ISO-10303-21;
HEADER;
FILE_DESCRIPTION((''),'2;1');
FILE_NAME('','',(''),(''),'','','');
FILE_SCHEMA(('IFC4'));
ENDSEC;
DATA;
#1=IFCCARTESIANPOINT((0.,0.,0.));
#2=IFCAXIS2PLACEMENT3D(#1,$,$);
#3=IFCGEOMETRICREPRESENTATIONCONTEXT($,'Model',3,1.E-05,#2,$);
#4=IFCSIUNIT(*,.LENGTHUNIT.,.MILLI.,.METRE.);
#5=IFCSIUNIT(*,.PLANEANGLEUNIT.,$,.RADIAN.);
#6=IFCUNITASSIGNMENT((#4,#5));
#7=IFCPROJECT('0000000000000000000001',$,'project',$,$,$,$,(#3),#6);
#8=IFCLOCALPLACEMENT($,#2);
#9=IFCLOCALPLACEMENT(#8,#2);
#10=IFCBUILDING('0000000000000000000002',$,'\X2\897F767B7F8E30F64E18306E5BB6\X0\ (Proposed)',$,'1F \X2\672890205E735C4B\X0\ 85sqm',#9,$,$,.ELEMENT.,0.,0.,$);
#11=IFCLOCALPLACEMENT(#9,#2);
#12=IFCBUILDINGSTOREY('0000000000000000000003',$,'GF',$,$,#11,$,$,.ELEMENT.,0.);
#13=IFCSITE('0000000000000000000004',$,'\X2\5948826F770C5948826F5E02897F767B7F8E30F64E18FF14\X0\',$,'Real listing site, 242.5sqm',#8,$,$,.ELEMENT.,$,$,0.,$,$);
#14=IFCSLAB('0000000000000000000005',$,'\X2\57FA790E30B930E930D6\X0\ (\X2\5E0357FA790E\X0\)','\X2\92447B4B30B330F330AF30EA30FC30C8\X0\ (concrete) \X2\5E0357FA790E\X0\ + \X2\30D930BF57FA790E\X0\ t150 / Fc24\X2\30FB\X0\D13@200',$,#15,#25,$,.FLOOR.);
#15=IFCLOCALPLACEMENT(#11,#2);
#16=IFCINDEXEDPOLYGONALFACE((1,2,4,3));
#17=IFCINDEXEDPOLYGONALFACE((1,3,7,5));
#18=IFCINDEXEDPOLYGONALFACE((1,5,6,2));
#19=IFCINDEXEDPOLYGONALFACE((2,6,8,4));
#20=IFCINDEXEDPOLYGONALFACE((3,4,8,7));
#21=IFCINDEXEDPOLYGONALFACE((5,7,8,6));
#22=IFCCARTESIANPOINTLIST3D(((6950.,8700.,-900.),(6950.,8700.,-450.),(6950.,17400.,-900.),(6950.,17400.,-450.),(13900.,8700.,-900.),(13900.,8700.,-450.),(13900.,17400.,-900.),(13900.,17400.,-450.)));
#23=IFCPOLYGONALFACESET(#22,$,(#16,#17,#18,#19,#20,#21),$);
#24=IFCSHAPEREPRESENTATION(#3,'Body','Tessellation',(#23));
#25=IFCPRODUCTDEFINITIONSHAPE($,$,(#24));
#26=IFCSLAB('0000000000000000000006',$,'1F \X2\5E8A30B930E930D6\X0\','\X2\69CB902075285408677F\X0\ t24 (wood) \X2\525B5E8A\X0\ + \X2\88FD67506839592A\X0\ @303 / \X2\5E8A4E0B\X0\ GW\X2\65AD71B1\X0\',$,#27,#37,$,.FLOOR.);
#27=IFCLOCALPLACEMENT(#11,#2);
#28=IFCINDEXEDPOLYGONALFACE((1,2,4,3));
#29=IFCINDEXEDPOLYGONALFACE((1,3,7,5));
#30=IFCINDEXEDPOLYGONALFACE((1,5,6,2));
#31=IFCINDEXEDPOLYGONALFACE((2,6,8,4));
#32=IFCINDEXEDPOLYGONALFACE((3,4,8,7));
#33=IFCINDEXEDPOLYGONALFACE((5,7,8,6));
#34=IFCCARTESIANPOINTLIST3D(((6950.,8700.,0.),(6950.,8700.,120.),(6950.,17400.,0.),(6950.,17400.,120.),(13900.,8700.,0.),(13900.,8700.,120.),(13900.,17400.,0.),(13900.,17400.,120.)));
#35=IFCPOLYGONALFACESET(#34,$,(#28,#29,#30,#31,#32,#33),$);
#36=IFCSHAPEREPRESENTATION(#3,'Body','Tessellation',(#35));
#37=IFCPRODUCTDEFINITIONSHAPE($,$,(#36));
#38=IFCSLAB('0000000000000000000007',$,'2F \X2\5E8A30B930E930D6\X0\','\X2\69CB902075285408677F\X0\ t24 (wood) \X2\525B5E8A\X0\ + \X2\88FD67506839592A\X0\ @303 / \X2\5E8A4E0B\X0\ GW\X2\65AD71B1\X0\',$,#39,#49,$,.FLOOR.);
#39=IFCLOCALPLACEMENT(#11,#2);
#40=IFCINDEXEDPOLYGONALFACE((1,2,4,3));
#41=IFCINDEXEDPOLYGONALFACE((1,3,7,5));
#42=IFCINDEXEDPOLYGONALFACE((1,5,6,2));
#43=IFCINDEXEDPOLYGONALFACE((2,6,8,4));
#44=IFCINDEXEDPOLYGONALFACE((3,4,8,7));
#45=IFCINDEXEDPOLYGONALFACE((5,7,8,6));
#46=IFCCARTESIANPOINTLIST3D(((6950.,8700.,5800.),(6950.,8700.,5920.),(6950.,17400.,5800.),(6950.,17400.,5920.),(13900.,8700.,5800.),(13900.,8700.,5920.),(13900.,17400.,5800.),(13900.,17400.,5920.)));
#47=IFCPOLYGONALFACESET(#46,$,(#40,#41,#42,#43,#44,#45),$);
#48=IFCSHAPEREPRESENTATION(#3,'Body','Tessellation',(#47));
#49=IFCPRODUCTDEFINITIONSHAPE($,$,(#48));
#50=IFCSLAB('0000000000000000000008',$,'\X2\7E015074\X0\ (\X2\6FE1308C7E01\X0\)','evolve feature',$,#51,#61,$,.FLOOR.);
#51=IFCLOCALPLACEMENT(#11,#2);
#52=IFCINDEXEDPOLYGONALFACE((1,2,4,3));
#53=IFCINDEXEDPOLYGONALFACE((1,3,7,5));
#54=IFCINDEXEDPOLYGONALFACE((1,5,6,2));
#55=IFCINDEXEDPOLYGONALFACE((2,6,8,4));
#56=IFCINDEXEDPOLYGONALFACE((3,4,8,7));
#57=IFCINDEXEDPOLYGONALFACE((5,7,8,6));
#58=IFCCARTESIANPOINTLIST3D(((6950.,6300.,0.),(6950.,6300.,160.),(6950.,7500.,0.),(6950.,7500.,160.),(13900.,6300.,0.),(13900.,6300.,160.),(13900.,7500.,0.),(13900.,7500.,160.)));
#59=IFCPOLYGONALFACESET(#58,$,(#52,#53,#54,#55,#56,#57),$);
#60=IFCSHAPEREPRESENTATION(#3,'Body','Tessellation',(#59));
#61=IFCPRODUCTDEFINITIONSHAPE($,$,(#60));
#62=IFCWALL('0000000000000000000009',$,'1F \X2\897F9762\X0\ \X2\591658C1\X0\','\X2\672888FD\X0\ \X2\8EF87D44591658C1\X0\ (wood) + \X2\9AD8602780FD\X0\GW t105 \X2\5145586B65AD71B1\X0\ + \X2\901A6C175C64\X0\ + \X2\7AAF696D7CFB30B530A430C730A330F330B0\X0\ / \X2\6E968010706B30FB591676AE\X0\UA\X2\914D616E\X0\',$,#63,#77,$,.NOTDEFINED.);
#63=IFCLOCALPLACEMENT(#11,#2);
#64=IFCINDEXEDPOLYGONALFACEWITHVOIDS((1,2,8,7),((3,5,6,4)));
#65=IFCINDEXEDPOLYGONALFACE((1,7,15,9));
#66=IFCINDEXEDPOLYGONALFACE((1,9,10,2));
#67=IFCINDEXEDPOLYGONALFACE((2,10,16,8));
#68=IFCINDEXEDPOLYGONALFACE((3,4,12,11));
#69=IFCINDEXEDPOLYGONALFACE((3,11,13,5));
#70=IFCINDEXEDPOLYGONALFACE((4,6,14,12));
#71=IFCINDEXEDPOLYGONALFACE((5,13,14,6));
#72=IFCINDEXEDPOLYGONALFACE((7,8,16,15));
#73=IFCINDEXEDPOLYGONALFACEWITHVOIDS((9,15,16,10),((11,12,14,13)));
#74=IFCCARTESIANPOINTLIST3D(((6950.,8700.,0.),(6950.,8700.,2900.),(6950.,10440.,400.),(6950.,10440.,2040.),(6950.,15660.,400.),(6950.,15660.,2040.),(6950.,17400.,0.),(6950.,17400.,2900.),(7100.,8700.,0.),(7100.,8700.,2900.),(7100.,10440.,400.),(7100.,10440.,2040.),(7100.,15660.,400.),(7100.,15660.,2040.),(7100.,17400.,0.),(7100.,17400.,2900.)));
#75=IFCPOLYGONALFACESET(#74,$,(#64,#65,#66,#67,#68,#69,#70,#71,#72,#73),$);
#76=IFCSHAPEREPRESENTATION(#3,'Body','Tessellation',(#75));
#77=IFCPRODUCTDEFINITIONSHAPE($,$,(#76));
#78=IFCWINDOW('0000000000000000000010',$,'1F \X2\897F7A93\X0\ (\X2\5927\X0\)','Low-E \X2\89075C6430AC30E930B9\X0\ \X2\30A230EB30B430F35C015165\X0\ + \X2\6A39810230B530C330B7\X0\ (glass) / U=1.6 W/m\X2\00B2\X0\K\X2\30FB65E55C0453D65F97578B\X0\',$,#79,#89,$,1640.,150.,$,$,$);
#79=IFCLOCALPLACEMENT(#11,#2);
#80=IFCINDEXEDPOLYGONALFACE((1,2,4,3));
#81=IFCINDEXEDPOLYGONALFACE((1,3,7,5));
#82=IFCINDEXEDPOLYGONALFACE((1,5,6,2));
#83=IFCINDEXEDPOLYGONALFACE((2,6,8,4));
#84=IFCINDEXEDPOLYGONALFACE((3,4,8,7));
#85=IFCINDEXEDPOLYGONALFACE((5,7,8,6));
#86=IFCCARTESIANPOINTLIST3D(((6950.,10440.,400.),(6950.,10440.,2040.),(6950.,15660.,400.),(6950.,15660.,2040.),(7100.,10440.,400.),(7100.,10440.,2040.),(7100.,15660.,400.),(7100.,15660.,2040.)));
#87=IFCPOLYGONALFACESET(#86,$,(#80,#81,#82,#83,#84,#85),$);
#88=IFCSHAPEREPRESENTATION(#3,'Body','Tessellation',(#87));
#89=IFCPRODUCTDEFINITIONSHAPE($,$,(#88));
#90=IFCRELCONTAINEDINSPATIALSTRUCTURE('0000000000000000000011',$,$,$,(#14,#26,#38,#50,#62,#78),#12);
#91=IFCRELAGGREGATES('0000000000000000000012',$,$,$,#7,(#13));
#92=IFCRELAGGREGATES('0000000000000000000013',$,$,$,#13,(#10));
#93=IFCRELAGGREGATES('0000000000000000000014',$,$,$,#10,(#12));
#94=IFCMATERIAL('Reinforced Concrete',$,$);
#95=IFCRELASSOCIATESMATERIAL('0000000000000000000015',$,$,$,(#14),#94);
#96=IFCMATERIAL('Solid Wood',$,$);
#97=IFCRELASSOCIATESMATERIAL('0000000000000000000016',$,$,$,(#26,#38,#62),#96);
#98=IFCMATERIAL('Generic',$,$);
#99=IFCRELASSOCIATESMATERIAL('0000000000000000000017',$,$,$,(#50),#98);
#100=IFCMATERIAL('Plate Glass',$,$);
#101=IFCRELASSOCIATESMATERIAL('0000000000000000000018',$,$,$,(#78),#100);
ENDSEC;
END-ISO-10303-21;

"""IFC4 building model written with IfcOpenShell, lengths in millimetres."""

from ifc_helpers import new_model, si_unit, frame, frame_2d, origin, place, context, project, spatial, rectangle, extrude, material, element, fill, save


model = new_model("IFC4")

# Units and contexts
model_context = context("Model", 3, precision=1e-05, world=origin())
ifc_project = project(units=[si_unit("LENGTHUNIT", "METRE", prefix="MILLI"), si_unit("PLANEANGLEUNIT", "RADIAN")], contexts=[model_context])

# Site, building, storey
site_placement = place(None, origin())
site = spatial("IfcSite", under=ifc_project, at=site_placement, Name="奈良県奈良市西登美ヶ丘４", ObjectType="Real listing site, 242.5sqm", CompositionType="ELEMENT", RefElevation=0.0)
building_placement = place(site_placement, origin())
building = spatial("IfcBuilding", under=site, at=building_placement, Name="西登美ヶ丘の家 (Proposed)", ObjectType="1F 木造平屋 85sqm", CompositionType="ELEMENT", ElevationOfRefHeight=0.0, ElevationOfTerrain=0.0)
storey_placement = place(building_placement, origin())
storey = spatial("IfcBuildingStorey", under=building, at=storey_placement, Name="GF", CompositionType="ELEMENT", Elevation=0.0)

# Slabs
ifc_material_1 = material(Name="Reinforced Concrete")
slab_1_placement = place(storey_placement, frame((3475.0, 4350.0, -450.0)))
element("IfcSlab", 1, at=slab_1_placement, inside=storey, material=ifc_material_1, Name="基礎スラブ (布基礎)", Description="鉄筋コンクリート (concrete) 布基礎 + ベタ基礎 t150 / Fc24・D13@200", PredefinedType="FLOOR", context=model_context, shape_type="SweptSolid", body=[
    extrude(rectangle(XDim=6950.0, YDim=8700.0, at=frame_2d((3475.0, 4350.0))), frame((3475.0, 4350.0, -450.0)), (0.0, 0.0, 1.0), 450.0),
])
ifc_material_2 = material(Name="Solid Wood")
slab_2_placement = place(storey_placement, frame((3475.0, 4350.0, 0.0)))
element("IfcSlab", 2, at=slab_2_placement, inside=storey, material=ifc_material_2, Name="1F 床スラブ", Description="構造用合板 t24 (wood) 剛床 + 製材根太 @303 / 床下 GW断熱", PredefinedType="FLOOR", context=model_context, shape_type="SweptSolid", body=[
    extrude(rectangle(XDim=6950.0, YDim=8700.0, at=frame_2d((3475.0, 4350.0))), frame((3475.0, 4350.0, 0.0)), (0.0, 0.0, 1.0), 120.0),
])
slab_3_placement = place(storey_placement, frame((3475.0, 4350.0, 2900.0)))
element("IfcSlab", 3, at=slab_3_placement, inside=storey, material=ifc_material_2, Name="2F 床スラブ", Description="構造用合板 t24 (wood) 剛床 + 製材根太 @303 / 床下 GW断熱", PredefinedType="FLOOR", context=model_context, shape_type="SweptSolid", body=[
    extrude(rectangle(XDim=6950.0, YDim=8700.0, at=frame_2d((3475.0, 4350.0))), frame((3475.0, 4350.0, 2900.0)), (0.0, 0.0, 1.0), 120.0),
])
ifc_material_3 = material(Name="Generic")
slab_4_placement = place(storey_placement, frame((3475.0, 3150.0, 0.0)))
element("IfcSlab", 4, at=slab_4_placement, inside=storey, material=ifc_material_3, Name="縁側 (濡れ縁)", Description="evolve feature", PredefinedType="FLOOR", context=model_context, shape_type="SweptSolid", body=[
    extrude(rectangle(XDim=6950.0, YDim=1200.0, at=frame_2d((3475.0, 600.0))), frame((3475.0, 3150.0, 0.0)), (0.0, 0.0, 1.0), 160.0),
])

# Shared definitions
ifc_material_4 = material(Name="Plate Glass")

# Wall, opening, window
wall_1_placement = place(storey_placement, frame((3475.0, 4350.0, 0.0)))
wall_1 = element("IfcWall", 5, at=wall_1_placement, inside=storey, material=ifc_material_2, Name="1F 西面 外壁", Description="木製 軸組外壁 (wood) + 高性能GW t105 充填断熱 + 通気層 + 窯業系サイディング / 準耐火・外皮UA配慮", PredefinedType="NOTDEFINED", context=model_context, shape_type="SweptSolid", body=[
    extrude(rectangle(XDim=150.0, YDim=8700.0, at=frame_2d((75.0, 4350.0))), frame((3475.0, 4350.0, 0.0)), (0.0, 0.0, 1.0), 2900.0),
])
opening_1_placement = place(storey_placement, frame((3475.0, 5220.0, 200.0)))
opening_1 = element("IfcOpeningElement", 6, at=opening_1_placement, cuts=wall_1, PredefinedType="NOTDEFINED", context=model_context, shape_type="SweptSolid", body=[
    extrude(rectangle(XDim=150.0, YDim=5220.0, at=frame_2d((75.0, 2610.0))), frame((3475.0, 5220.0, 200.0)), (0.0, 0.0, 1.0), 1640.0),
])
window_1_placement = place(storey_placement, frame((3475.0, 5220.0, 200.0)))
window_1 = element("IfcWindow", 7, at=window_1_placement, inside=storey, material=ifc_material_4, Name="1F 西窓 (大)", Description="Low-E 複層ガラス アルゴン封入 + 樹脂サッシ (glass) / U=1.6 W/m²K・日射取得型", OverallHeight=1640.0, OverallWidth=150.0, context=model_context, shape_type="SweptSolid", body=[
    extrude(rectangle(XDim=150.0, YDim=5220.0, at=frame_2d((75.0, 2610.0))), frame((3475.0, 5220.0, 200.0)), (0.0, 0.0, 1.0), 1640.0),
])
fill(opening_1, window_1)

save(model, "model.ifc")
